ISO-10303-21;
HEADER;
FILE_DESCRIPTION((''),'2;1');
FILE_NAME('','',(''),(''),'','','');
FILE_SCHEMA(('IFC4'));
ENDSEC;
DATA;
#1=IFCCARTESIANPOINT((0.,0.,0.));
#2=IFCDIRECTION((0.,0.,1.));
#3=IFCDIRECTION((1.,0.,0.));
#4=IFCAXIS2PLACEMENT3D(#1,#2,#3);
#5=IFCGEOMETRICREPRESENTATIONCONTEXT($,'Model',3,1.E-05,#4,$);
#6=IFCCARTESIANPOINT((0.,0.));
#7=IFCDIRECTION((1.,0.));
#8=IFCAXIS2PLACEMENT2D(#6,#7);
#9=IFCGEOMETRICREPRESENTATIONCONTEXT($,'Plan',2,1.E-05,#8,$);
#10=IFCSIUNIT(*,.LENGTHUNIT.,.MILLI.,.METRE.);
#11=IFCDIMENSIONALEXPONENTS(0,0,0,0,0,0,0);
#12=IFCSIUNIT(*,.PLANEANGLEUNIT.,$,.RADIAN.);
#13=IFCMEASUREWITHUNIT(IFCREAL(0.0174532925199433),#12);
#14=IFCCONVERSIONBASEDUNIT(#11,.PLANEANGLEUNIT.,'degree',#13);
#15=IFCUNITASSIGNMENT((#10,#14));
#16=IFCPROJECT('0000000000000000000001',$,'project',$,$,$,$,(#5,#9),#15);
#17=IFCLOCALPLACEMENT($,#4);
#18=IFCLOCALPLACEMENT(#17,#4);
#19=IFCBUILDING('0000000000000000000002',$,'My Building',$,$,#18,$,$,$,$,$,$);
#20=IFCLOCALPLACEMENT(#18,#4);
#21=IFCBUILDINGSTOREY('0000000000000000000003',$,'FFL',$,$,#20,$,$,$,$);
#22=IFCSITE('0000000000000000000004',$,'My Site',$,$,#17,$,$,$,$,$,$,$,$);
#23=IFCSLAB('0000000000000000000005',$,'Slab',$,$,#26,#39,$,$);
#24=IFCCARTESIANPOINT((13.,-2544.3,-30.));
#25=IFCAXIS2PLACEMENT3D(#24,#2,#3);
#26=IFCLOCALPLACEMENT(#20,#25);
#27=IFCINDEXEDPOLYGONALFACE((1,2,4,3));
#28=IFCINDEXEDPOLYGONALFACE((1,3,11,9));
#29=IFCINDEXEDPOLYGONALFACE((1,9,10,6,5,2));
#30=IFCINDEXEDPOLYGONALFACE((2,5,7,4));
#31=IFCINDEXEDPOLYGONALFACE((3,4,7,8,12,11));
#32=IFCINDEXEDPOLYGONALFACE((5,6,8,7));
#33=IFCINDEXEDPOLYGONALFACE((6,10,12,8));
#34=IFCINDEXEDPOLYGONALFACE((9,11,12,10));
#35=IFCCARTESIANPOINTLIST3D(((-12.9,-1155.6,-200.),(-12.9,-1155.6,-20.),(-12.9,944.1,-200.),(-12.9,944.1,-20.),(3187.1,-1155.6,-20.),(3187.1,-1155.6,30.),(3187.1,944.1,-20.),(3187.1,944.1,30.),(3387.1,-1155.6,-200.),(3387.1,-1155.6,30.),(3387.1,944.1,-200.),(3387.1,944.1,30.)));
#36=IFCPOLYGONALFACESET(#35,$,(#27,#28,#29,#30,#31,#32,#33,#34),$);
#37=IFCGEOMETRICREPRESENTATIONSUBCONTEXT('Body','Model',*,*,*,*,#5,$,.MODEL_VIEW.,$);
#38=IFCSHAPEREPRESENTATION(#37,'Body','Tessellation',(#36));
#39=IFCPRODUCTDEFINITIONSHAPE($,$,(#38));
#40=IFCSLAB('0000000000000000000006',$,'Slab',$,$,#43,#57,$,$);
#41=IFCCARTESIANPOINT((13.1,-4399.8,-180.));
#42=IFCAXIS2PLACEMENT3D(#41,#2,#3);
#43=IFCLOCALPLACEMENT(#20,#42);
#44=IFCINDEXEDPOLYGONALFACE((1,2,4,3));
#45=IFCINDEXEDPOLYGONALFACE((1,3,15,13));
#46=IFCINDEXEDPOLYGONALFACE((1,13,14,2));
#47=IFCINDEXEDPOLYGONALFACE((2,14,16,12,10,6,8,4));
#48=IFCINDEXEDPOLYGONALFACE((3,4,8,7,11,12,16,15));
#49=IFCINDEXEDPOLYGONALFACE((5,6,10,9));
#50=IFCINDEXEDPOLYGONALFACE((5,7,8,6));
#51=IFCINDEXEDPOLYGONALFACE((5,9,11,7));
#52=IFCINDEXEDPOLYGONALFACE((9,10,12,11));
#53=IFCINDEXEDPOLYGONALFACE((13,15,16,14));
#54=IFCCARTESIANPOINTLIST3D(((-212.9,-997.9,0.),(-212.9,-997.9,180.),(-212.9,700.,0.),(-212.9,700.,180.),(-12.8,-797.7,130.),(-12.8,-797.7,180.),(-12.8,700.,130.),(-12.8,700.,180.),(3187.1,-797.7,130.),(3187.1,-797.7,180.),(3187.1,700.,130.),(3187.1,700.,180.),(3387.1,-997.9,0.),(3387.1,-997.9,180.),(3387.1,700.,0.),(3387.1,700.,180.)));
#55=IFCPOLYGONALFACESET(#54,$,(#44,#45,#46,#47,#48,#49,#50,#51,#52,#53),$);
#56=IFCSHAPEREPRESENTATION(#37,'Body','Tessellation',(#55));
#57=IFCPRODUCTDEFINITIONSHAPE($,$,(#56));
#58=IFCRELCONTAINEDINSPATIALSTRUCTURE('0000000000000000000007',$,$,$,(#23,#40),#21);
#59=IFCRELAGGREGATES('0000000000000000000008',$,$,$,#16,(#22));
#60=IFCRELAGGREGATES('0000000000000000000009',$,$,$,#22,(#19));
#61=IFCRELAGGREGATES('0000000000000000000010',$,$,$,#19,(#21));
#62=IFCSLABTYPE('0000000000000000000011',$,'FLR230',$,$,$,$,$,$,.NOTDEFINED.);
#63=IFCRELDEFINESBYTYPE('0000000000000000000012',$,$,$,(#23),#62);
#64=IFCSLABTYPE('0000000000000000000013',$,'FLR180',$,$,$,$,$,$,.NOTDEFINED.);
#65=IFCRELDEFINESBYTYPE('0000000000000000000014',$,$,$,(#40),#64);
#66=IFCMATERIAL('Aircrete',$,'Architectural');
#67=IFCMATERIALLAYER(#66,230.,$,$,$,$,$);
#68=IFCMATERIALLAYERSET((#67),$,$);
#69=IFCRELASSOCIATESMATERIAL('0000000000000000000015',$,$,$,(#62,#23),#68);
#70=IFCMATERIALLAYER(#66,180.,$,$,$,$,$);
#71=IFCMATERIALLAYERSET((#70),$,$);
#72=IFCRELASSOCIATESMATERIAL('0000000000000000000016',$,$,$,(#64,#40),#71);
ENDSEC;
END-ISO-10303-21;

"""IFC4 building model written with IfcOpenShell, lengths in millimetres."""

from ifc_helpers import new_model, entity, si_unit, converted_unit, frame, origin_with_axes, origin_2d_with_axis, place, context, subcontext, project, spatial, indexed_curve, outline, extrude, material, layer, layer_set, layer_usage, type_object, element, save


model = new_model("IFC4")

# Units and contexts
model_context = context("Model", 3, precision=1e-05, world=origin_with_axes())
plan_context = context("Plan", 2, precision=1e-05, world=origin_2d_with_axis())
body_context_1 = subcontext(model_context, "Body", "Model", "MODEL_VIEW")
ifc_project = project(units=[si_unit("LENGTHUNIT", "METRE", prefix="MILLI"), converted_unit("PLANEANGLEUNIT", "degree", entity("IfcReal", 0.0174532925199433), si_unit("PLANEANGLEUNIT", "RADIAN"), dimensions=[0, 0, 0, 0, 0, 0, 0])], contexts=[model_context, plan_context])

# Site, building, storey
site_placement = place(None, origin_with_axes())
site = spatial("IfcSite", under=ifc_project, at=site_placement, Name="My Site")
building_placement = place(site_placement, origin_with_axes())
building = spatial("IfcBuilding", under=site, at=building_placement, Name="My Building")
storey_placement = place(building_placement, origin_with_axes())
storey = spatial("IfcBuildingStorey", under=building, at=storey_placement, Name="FFL")

# Shared definitions
ifc_material_1 = material(Name="Aircrete", Category="Architectural")
ifc_layer_1 = layer(ifc_material_1, 230.0)
ifc_layer_set_1 = layer_set([ifc_layer_1])
slab_type_1 = type_object("IfcSlabType", Name="FLR230", PredefinedType="NOTDEFINED", material=ifc_layer_set_1)

# Slabs, openings
ifc_layer_usage_1 = layer_usage(ifc_layer_set_1, "AXIS3", "POSITIVE", -200.0)
slab_1_placement = place(storey_placement, frame((13.0, -2544.3, -30.0), z_axis=(0.0, 0.0, 1.0), x_axis=(1.0, 0.0, 0.0)))
slab_1 = element("IfcSlab", 1, at=slab_1_placement, inside=storey, type_object=slab_type_1, material=ifc_layer_usage_1, Name="Slab", context=body_context_1, shape_type="SweptSolid", body=[
    extrude(outline(indexed_curve([(-12.9, -1155.6), (3387.1, -1155.6), (3387.1, 944.1), (-12.9, 944.1), (-12.9, -1155.6)])), frame((0.0, 0.0, -200.0), z_axis=(0.0, 0.0, 1.0), x_axis=(1.0, 0.0, 0.0)), (0.0, 0.0, 1.0), 230.0),
])
opening_1_placement = place(slab_1_placement, frame((0.0, 0.0, 30.0), z_axis=(0.0, 0.0, 1.0), x_axis=(1.0, 0.0, 0.0)))
element("IfcOpeningElement", 2, at=opening_1_placement, cuts=slab_1, PredefinedType="OPENING", context=body_context_1, shape_type="SweptSolid", body=[
    extrude(outline(indexed_curve([(-13.5, 944.1), (3187.1, 944.1), (3187.1, -1155.6), (-13.5, -1155.6), (-13.5, 944.1)])), frame((0.0, 0.0, -50.0), z_axis=(0.0, 0.0, 1.0), x_axis=(1.0, 0.0, 0.0)), (0.0, 0.0, 1.0), 100.0),
])
ifc_layer_2 = layer(ifc_material_1, 180.0)
ifc_layer_set_2 = layer_set([ifc_layer_2])
ifc_layer_usage_2 = layer_usage(ifc_layer_set_2, "AXIS3", "POSITIVE", 0.0)
slab_type_2 = type_object("IfcSlabType", Name="FLR180", PredefinedType="NOTDEFINED", material=ifc_layer_set_2)
slab_2_placement = place(storey_placement, frame((13.1, -4399.8, -180.0), z_axis=(0.0, 0.0, 1.0), x_axis=(1.0, 0.0, 0.0)))
slab_2 = element("IfcSlab", 3, at=slab_2_placement, inside=storey, type_object=slab_type_2, material=ifc_layer_usage_2, Name="Slab", context=body_context_1, shape_type="SweptSolid", body=[
    extrude(outline(indexed_curve([(-212.9, -997.9), (3387.1, -997.9), (3387.1, 700.0), (-212.9, 700.0), (-212.9, -997.9)])), None, (0.0, 0.0, 1.0), 180.0),
])
opening_2_placement = place(slab_2_placement, frame((-12.8, 706.5, 130.0), z_axis=(0.0, 0.0, 1.0), x_axis=(0.0, -1.0, 0.0)))
element("IfcOpeningElement", 4, at=opening_2_placement, cuts=slab_2, PredefinedType="OPENING", context=body_context_1, shape_type="SweptSolid", body=[
    extrude(outline(indexed_curve([(0.0, 0.0), (1504.2, 0.0), (1504.2, 3200.0), (0.0, 3200.0), (0.0, 0.0)])), origin_with_axes(), (0.0, 0.0, 1.0), 100.0),
])

save(model, "model.ifc")
